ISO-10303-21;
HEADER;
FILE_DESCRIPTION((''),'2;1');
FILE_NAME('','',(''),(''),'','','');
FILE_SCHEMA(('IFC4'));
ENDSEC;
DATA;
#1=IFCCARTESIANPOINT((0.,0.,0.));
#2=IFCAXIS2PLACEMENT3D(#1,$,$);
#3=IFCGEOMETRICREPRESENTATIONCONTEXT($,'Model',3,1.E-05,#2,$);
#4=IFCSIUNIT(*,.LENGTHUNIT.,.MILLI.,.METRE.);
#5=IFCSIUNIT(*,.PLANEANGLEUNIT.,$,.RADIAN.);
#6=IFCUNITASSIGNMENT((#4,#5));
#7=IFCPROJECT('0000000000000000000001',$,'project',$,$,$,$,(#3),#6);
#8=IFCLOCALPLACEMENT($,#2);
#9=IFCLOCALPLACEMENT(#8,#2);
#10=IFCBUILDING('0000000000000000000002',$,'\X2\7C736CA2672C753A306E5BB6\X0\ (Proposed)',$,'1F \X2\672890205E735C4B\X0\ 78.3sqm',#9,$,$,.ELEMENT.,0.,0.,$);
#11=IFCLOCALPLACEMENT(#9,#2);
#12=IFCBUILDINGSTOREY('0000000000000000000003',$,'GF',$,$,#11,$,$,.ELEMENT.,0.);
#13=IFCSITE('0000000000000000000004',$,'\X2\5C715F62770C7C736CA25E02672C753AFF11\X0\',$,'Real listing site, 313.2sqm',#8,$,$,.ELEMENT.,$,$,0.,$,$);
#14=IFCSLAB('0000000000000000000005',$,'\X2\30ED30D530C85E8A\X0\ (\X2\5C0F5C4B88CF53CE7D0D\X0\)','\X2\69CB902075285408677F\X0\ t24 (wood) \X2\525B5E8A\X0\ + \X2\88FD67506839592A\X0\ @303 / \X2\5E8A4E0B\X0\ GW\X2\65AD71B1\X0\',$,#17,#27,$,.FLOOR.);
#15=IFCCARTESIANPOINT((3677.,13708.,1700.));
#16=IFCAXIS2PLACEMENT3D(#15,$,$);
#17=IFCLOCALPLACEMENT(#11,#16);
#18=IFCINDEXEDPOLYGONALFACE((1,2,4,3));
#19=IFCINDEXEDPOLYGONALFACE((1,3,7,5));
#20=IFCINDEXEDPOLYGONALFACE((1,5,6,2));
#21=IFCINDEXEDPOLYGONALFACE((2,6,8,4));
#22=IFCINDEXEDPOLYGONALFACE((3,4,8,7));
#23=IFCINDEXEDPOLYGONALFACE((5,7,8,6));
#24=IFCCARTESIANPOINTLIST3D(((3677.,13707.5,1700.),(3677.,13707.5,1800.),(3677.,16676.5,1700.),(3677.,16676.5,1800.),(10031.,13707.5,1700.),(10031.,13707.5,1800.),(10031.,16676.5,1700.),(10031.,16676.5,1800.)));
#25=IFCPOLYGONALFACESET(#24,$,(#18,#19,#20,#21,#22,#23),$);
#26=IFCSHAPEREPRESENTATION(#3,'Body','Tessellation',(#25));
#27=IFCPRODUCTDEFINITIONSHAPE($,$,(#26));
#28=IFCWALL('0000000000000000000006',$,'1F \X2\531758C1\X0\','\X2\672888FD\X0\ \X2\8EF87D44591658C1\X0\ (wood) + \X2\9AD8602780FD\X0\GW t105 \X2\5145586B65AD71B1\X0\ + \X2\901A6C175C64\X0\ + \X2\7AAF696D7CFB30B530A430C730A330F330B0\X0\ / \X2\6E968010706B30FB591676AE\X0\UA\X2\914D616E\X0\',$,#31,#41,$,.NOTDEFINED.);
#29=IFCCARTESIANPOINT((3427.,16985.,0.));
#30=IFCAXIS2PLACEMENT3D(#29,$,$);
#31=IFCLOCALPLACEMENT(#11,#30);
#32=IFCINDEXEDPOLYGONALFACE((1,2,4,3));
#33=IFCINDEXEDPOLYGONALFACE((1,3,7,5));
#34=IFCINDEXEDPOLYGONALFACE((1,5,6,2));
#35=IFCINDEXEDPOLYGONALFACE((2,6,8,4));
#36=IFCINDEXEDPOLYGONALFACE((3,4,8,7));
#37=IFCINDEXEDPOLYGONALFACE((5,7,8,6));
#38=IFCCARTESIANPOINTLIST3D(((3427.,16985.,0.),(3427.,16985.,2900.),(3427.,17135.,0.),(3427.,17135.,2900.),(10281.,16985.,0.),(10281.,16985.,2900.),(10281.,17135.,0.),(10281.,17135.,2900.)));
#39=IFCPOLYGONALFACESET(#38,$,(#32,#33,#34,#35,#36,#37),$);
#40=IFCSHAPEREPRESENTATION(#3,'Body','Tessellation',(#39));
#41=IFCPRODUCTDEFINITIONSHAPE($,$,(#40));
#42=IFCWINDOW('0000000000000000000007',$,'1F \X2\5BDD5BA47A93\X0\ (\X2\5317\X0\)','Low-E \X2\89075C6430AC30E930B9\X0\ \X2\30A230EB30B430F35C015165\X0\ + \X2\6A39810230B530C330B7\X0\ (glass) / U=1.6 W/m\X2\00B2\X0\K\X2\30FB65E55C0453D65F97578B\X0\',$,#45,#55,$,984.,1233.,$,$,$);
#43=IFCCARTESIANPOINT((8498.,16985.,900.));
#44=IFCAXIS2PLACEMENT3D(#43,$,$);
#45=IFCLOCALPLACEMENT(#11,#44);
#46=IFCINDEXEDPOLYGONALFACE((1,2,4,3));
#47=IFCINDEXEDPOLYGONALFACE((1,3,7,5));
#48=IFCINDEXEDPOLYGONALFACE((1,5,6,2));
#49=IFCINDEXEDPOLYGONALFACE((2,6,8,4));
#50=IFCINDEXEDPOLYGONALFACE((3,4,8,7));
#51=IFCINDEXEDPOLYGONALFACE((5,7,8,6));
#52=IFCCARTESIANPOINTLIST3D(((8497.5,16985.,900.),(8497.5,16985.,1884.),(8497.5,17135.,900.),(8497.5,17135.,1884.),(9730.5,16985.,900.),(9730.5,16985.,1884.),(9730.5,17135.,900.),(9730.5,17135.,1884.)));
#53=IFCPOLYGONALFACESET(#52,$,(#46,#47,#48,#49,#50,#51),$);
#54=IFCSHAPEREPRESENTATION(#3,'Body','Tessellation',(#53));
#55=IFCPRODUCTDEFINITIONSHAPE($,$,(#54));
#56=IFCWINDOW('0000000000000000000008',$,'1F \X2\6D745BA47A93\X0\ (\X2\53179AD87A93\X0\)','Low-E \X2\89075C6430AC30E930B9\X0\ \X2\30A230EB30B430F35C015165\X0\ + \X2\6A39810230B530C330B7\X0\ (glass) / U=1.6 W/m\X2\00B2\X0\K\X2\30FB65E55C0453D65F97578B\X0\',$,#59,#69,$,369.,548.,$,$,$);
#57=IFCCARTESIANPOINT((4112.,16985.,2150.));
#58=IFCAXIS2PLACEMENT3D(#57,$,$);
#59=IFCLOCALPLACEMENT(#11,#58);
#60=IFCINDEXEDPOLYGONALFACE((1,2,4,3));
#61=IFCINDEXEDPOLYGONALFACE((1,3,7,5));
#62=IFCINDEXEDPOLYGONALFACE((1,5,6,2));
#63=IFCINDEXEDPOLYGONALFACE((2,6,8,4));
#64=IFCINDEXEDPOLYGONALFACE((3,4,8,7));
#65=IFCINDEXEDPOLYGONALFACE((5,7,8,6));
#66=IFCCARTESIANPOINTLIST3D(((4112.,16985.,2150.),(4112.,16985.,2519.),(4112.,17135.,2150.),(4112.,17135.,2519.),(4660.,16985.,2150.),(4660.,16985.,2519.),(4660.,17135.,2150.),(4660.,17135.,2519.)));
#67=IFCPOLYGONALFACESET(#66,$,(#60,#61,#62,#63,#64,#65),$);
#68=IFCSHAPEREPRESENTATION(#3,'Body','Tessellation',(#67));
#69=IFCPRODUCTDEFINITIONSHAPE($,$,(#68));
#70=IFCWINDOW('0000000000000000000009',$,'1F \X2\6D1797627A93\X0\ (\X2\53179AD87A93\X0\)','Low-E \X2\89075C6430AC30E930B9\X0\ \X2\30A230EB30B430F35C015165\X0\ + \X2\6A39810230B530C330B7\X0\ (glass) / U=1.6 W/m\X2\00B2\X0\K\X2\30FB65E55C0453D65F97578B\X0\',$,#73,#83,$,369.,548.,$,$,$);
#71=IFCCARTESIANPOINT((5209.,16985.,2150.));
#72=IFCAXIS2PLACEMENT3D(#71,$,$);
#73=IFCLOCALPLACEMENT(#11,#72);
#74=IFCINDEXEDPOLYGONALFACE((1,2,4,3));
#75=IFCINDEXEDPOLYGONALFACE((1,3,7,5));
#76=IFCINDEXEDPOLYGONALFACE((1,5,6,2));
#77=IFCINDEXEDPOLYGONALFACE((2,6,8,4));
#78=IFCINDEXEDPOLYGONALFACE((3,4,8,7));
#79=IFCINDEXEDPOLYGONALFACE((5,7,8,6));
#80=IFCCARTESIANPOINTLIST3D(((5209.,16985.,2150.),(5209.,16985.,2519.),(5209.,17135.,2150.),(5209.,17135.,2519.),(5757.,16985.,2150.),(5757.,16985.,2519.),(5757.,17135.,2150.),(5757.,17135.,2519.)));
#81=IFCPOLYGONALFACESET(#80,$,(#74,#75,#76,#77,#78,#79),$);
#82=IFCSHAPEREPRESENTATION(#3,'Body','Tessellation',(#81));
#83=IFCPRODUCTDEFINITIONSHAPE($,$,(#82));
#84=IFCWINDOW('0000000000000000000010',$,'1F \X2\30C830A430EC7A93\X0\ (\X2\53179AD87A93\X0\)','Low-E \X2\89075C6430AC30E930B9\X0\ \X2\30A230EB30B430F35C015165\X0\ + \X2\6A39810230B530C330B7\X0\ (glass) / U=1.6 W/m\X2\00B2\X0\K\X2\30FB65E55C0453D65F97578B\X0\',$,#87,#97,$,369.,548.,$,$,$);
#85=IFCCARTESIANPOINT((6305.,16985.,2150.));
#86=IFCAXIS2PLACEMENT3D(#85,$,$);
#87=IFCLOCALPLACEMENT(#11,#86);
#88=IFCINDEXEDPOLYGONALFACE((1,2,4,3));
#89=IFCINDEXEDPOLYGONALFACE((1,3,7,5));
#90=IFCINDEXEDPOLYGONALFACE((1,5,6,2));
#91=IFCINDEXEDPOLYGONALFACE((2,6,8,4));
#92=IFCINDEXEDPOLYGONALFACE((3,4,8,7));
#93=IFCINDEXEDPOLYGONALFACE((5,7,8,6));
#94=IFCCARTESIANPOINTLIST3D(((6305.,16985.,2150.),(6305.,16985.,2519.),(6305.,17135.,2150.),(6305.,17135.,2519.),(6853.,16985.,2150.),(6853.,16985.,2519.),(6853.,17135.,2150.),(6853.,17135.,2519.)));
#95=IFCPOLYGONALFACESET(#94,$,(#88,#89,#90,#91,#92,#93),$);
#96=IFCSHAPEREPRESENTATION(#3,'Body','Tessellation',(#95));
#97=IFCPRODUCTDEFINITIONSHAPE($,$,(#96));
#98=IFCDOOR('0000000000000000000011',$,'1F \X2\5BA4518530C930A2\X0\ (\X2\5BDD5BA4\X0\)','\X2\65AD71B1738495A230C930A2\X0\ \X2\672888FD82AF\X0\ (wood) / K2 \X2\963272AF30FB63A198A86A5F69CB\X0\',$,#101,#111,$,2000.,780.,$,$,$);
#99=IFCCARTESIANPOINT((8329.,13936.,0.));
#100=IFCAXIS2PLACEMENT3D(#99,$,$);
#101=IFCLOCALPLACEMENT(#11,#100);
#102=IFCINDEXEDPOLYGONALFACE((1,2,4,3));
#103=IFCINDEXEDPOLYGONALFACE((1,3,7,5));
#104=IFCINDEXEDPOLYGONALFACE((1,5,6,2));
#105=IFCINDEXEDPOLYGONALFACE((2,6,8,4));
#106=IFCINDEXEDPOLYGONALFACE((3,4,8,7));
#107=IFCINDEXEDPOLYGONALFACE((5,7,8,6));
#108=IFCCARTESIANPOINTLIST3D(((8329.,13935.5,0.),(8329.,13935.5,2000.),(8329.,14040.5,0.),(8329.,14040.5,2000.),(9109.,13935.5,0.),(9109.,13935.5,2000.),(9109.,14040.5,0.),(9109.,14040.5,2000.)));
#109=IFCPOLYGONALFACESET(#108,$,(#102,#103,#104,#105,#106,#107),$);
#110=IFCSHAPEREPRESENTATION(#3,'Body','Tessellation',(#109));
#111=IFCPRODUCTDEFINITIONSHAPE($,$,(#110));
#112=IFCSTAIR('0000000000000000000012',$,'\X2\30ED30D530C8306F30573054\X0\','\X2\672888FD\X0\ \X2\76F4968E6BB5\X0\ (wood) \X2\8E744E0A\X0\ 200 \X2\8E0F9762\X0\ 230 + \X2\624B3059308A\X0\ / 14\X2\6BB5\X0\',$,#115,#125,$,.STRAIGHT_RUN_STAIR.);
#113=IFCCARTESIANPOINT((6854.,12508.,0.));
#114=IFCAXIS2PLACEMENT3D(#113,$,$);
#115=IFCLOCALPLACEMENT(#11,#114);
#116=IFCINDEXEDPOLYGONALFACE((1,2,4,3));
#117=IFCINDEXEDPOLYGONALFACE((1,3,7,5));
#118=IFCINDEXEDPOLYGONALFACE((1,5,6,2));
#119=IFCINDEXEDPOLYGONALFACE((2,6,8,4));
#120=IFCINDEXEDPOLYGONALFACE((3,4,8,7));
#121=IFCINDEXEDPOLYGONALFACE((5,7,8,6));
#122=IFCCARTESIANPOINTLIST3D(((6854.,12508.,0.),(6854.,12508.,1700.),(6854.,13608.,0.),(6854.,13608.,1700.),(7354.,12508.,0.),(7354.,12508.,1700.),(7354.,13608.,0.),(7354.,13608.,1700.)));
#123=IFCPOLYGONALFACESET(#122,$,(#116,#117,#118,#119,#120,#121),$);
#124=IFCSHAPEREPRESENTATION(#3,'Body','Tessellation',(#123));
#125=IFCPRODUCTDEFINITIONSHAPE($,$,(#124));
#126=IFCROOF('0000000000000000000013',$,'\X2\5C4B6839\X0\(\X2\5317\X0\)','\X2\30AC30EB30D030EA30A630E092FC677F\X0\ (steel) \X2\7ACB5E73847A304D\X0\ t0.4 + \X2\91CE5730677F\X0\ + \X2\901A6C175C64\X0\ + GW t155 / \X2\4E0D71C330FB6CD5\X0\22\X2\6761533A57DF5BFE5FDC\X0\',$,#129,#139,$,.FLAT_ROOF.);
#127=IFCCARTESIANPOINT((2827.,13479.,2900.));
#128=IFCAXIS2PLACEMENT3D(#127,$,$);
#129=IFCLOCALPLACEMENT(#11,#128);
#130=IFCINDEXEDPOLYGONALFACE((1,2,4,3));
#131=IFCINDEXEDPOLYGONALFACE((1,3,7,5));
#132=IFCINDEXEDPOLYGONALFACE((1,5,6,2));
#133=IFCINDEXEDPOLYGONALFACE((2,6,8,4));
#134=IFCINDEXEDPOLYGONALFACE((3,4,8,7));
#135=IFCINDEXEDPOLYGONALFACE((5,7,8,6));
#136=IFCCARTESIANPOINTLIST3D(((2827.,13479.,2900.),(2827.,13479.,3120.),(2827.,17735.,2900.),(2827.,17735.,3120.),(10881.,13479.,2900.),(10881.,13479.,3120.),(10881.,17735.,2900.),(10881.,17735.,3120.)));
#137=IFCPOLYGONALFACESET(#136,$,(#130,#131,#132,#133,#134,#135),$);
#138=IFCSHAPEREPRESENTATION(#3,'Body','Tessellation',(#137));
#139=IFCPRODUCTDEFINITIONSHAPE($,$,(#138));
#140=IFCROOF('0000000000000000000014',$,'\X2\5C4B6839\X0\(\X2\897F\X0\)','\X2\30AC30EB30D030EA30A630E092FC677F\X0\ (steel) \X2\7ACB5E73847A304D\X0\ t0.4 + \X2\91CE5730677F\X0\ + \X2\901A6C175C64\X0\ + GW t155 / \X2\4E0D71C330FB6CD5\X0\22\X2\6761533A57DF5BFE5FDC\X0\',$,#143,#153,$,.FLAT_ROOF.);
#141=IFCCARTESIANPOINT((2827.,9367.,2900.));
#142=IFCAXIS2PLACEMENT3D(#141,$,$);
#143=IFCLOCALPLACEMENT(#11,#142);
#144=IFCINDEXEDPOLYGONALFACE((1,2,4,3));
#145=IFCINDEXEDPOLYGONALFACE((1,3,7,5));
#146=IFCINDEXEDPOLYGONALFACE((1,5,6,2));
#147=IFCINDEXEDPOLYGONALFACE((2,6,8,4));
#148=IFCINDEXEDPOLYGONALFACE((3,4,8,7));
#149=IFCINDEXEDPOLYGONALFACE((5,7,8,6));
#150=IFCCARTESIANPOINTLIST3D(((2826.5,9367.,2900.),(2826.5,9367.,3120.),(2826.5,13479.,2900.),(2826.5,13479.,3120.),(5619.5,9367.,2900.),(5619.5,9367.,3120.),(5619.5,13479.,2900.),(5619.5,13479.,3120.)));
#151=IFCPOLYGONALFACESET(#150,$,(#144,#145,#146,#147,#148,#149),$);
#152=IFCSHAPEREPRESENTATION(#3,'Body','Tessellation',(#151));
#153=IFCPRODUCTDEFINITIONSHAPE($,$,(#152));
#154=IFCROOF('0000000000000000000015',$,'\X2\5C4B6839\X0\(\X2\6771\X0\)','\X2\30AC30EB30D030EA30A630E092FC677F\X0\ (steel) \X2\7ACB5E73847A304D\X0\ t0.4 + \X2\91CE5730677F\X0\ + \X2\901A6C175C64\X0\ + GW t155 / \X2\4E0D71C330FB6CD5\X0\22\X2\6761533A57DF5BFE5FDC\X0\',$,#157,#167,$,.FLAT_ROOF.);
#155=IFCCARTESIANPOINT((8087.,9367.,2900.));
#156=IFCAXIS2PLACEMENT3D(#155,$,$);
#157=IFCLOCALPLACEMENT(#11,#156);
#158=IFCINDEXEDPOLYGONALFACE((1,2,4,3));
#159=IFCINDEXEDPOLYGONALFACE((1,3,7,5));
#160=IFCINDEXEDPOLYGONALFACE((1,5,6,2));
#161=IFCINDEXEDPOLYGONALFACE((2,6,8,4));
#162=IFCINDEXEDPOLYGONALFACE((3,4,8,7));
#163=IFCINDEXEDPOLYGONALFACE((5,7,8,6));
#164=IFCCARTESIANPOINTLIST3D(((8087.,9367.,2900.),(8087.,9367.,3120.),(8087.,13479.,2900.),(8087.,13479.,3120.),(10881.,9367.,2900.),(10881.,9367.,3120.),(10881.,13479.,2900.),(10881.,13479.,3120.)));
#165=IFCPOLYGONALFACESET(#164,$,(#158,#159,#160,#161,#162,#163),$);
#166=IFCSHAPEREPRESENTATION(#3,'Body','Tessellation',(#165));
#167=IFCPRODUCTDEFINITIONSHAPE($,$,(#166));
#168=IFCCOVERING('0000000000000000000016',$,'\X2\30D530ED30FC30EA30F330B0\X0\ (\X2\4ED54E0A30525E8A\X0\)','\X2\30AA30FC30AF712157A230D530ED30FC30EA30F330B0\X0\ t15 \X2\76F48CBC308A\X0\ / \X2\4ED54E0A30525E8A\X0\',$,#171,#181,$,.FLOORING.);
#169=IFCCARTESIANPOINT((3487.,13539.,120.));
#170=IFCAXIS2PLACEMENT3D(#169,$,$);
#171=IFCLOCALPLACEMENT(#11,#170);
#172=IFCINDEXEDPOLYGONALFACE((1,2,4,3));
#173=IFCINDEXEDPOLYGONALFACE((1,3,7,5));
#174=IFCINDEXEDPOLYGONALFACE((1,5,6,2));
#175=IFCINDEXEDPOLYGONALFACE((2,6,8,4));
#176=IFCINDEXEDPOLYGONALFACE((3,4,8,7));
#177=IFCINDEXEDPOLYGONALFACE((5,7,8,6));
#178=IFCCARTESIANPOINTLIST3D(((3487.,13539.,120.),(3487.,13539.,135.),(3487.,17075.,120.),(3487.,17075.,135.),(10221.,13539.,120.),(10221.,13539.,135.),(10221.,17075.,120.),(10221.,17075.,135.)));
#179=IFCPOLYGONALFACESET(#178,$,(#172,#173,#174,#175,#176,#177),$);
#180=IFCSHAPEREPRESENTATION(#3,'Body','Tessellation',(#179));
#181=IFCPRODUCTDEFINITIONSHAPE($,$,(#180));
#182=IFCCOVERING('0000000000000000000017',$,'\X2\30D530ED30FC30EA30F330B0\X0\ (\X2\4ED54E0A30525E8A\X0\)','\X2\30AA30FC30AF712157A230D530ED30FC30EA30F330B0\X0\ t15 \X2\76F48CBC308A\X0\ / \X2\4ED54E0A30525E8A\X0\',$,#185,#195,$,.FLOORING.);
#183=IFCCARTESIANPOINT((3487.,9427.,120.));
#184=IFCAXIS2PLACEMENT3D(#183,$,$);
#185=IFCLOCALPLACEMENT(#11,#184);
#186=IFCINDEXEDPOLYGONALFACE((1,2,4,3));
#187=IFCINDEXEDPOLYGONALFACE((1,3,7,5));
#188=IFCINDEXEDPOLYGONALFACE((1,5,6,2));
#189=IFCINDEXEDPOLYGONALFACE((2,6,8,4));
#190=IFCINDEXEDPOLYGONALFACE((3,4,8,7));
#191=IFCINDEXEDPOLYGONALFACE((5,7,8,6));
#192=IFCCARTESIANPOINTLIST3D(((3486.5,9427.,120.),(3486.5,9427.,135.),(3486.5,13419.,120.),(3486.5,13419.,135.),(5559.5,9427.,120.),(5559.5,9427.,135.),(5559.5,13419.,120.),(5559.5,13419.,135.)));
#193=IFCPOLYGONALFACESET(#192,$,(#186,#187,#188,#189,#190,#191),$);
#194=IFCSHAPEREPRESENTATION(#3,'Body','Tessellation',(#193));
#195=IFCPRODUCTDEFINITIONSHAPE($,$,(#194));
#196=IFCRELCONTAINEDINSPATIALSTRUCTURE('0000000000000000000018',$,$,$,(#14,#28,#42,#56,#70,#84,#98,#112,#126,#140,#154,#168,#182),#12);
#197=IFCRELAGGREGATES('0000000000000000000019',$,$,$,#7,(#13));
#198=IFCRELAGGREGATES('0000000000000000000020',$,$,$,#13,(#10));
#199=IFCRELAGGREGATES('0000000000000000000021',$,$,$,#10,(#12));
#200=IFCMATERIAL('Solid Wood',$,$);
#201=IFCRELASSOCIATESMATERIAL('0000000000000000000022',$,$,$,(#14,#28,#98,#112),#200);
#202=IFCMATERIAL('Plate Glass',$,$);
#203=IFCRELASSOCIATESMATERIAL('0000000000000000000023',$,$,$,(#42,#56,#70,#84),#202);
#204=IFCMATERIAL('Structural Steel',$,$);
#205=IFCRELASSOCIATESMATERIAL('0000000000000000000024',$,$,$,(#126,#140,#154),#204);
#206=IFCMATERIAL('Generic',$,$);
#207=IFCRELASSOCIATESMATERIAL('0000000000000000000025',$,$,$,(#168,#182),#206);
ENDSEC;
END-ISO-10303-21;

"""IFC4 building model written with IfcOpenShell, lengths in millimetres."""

from ifc_helpers import new_model, si_unit, frame, frame_2d, origin, place, context, project, spatial, rectangle, extrude, material, element, fill, save


model = new_model("IFC4")

# Units and contexts
model_context = context("Model", 3, precision=1e-05, world=origin())
ifc_project = project(units=[si_unit("LENGTHUNIT", "METRE", prefix="MILLI"), si_unit("PLANEANGLEUNIT", "RADIAN")], contexts=[model_context])

# Site, building, storey
site_placement = place(None, origin())
site = spatial("IfcSite", under=ifc_project, at=site_placement, Name="山形県米沢市本町１", ObjectType="Real listing site, 313.2sqm", CompositionType="ELEMENT", RefElevation=0.0)
building_placement = place(site_placement, origin())
building = spatial("IfcBuilding", under=site, at=building_placement, Name="米沢本町の家 (Proposed)", ObjectType="1F 木造平屋 78.3sqm", CompositionType="ELEMENT", ElevationOfRefHeight=0.0, ElevationOfTerrain=0.0)
storey_placement = place(building_placement, origin())
storey = spatial("IfcBuildingStorey", under=building, at=storey_placement, Name="GF", CompositionType="ELEMENT", Elevation=0.0)

# Slab
ifc_material_1 = material(Name="Solid Wood")
slab_1_placement = place(storey_placement, frame((3677.0, 13708.0, 1700.0)))
element("IfcSlab", 1, at=slab_1_placement, inside=storey, material=ifc_material_1, Name="ロフト床 (小屋裏収納)", Description="構造用合板 t24 (wood) 剛床 + 製材根太 @303 / 床下 GW断熱", PredefinedType="FLOOR", context=model_context, shape_type="SweptSolid", body=[
    extrude(rectangle(XDim=6354.0, YDim=2969.0, at=frame_2d((3177.0, 1484.0))), frame((3677.0, 13708.0, 1700.0)), (0.0, 0.0, 1.0), 100.0),
])

# Wall, openings, windows
wall_1_placement = place(storey_placement, frame((3427.0, 16985.0, 0.0)))
wall_1 = element("IfcWall", 2, at=wall_1_placement, inside=storey, material=ifc_material_1, Name="1F 北壁", Description="木製 軸組外壁 (wood) + 高性能GW t105 充填断熱 + 通気層 + 窯業系サイディング / 準耐火・外皮UA配慮", PredefinedType="NOTDEFINED", context=model_context, shape_type="SweptSolid", body=[
    extrude(rectangle(XDim=6854.0, YDim=150.0, at=frame_2d((3427.0, 75.0))), frame((3427.0, 16985.0, 0.0)), (0.0, 0.0, 1.0), 2900.0),
])
opening_1_placement = place(storey_placement, frame((8498.0, 16985.0, 900.0)))
opening_1 = element("IfcOpeningElement", 3, at=opening_1_placement, cuts=wall_1, PredefinedType="NOTDEFINED", context=model_context, shape_type="SweptSolid", body=[
    extrude(rectangle(XDim=1233.0, YDim=150.0, at=frame_2d((616.0, 75.0))), frame((8498.0, 16985.0, 900.0)), (0.0, 0.0, 1.0), 984.0),
])
opening_2_placement = place(storey_placement, frame((4112.0, 16985.0, 2150.0)))
opening_2 = element("IfcOpeningElement", 4, at=opening_2_placement, cuts=wall_1, PredefinedType="NOTDEFINED", context=model_context, shape_type="SweptSolid", body=[
    extrude(rectangle(XDim=548.0, YDim=150.0, at=frame_2d((274.0, 75.0))), frame((4112.0, 16985.0, 2150.0)), (0.0, 0.0, 1.0), 369.0),
])
opening_3_placement = place(storey_placement, frame((5209.0, 16985.0, 2150.0)))
opening_3 = element("IfcOpeningElement", 5, at=opening_3_placement, cuts=wall_1, PredefinedType="NOTDEFINED", context=model_context, shape_type="SweptSolid", body=[
    extrude(rectangle(XDim=548.0, YDim=150.0, at=frame_2d((274.0, 75.0))), frame((5209.0, 16985.0, 2150.0)), (0.0, 0.0, 1.0), 369.0),
])
opening_4_placement = place(storey_placement, frame((6305.0, 16985.0, 2150.0)))
opening_4 = element("IfcOpeningElement", 6, at=opening_4_placement, cuts=wall_1, PredefinedType="NOTDEFINED", context=model_context, shape_type="SweptSolid", body=[
    extrude(rectangle(XDim=548.0, YDim=150.0, at=frame_2d((274.0, 75.0))), frame((6305.0, 16985.0, 2150.0)), (0.0, 0.0, 1.0), 369.0),
])
ifc_material_2 = material(Name="Plate Glass")
window_1_placement = place(storey_placement, frame((8498.0, 16985.0, 900.0)))
window_1 = element("IfcWindow", 7, at=window_1_placement, inside=storey, material=ifc_material_2, Name="1F 寝室窓 (北)", Description="Low-E 複層ガラス アルゴン封入 + 樹脂サッシ (glass) / U=1.6 W/m²K・日射取得型", OverallHeight=984.0, OverallWidth=1233.0, context=model_context, shape_type="SweptSolid", body=[
    extrude(rectangle(XDim=1233.0, YDim=150.0, at=frame_2d((616.0, 75.0))), frame((8498.0, 16985.0, 900.0)), (0.0, 0.0, 1.0), 984.0),
])
fill(opening_1, window_1)
window_2_placement = place(storey_placement, frame((4112.0, 16985.0, 2150.0)))
window_2 = element("IfcWindow", 8, at=window_2_placement, inside=storey, material=ifc_material_2, Name="1F 浴室窓 (北高窓)", Description="Low-E 複層ガラス アルゴン封入 + 樹脂サッシ (glass) / U=1.6 W/m²K・日射取得型", OverallHeight=369.0, OverallWidth=548.0, context=model_context, shape_type="SweptSolid", body=[
    extrude(rectangle(XDim=548.0, YDim=150.0, at=frame_2d((274.0, 75.0))), frame((4112.0, 16985.0, 2150.0)), (0.0, 0.0, 1.0), 369.0),
])
fill(opening_2, window_2)
window_3_placement = place(storey_placement, frame((5209.0, 16985.0, 2150.0)))
window_3 = element("IfcWindow", 9, at=window_3_placement, inside=storey, material=ifc_material_2, Name="1F 洗面窓 (北高窓)", Description="Low-E 複層ガラス アルゴン封入 + 樹脂サッシ (glass) / U=1.6 W/m²K・日射取得型", OverallHeight=369.0, OverallWidth=548.0, context=model_context, shape_type="SweptSolid", body=[
    extrude(rectangle(XDim=548.0, YDim=150.0, at=frame_2d((274.0, 75.0))), frame((5209.0, 16985.0, 2150.0)), (0.0, 0.0, 1.0), 369.0),
])
fill(opening_3, window_3)
window_4_placement = place(storey_placement, frame((6305.0, 16985.0, 2150.0)))
window_4 = element("IfcWindow", 10, at=window_4_placement, inside=storey, material=ifc_material_2, Name="1F トイレ窓 (北高窓)", Description="Low-E 複層ガラス アルゴン封入 + 樹脂サッシ (glass) / U=1.6 W/m²K・日射取得型", OverallHeight=369.0, OverallWidth=548.0, context=model_context, shape_type="SweptSolid", body=[
    extrude(rectangle(XDim=548.0, YDim=150.0, at=frame_2d((274.0, 75.0))), frame((6305.0, 16985.0, 2150.0)), (0.0, 0.0, 1.0), 369.0),
])
fill(opening_4, window_4)

# Door
door_1_placement = place(storey_placement, frame((8329.0, 13936.0, 0.0)))
element("IfcDoor", 11, at=door_1_placement, inside=storey, material=ifc_material_1, Name="1F 室内ドア (寝室)", Description="断熱玄関ドア 木製芯 (wood) / K2 防犯・採風機構", OverallHeight=2000.0, OverallWidth=780.0, context=model_context, shape_type="SweptSolid", body=[
    extrude(rectangle(XDim=780.0, YDim=105.0, at=frame_2d((390.0, 52.0))), frame((8329.0, 13936.0, 0.0)), (0.0, 0.0, 1.0), 2000.0),
])

# Stair
stair_placement = place(storey_placement, frame((6854.0, 12508.0, 0.0)))
element("IfcStair", 12, at=stair_placement, inside=storey, material=ifc_material_1, Name="ロフトはしご", Description="木製 直階段 (wood) 蹴上 200 踏面 230 + 手すり / 14段", PredefinedType="STRAIGHT_RUN_STAIR", context=model_context, shape_type="SweptSolid", body=[
    extrude(rectangle(XDim=500.0, YDim=1100.0, at=frame_2d((250.0, 550.0))), frame((6854.0, 12508.0, 0.0)), (0.0, 0.0, 1.0), 1700.0),
])

# Roofs
ifc_material_3 = material(Name="Structural Steel")
roof_1_placement = place(storey_placement, frame((2827.0, 13479.0, 2900.0)))
element("IfcRoof", 13, at=roof_1_placement, inside=storey, material=ifc_material_3, Name="屋根(北)", Description="ガルバリウム鋼板 (steel) 立平葺き t0.4 + 野地板 + 通気層 + GW t155 / 不燃・法22条区域対応", PredefinedType="FLAT_ROOF", context=model_context, shape_type="SweptSolid", body=[
    extrude(rectangle(XDim=8054.0, YDim=4256.0, at=frame_2d((4027.0, 2128.0))), frame((2827.0, 13479.0, 2900.0)), (0.0, 0.0, 1.0), 220.0),
])
roof_2_placement = place(storey_placement, frame((2827.0, 9367.0, 2900.0)))
element("IfcRoof", 14, at=roof_2_placement, inside=storey, material=ifc_material_3, Name="屋根(西)", Description="ガルバリウム鋼板 (steel) 立平葺き t0.4 + 野地板 + 通気層 + GW t155 / 不燃・法22条区域対応", PredefinedType="FLAT_ROOF", context=model_context, shape_type="SweptSolid", body=[
    extrude(rectangle(XDim=2793.0, YDim=4112.0, at=frame_2d((1396.0, 2056.0))), frame((2827.0, 9367.0, 2900.0)), (0.0, 0.0, 1.0), 220.0),
])
roof_3_placement = place(storey_placement, frame((8087.0, 9367.0, 2900.0)))
element("IfcRoof", 15, at=roof_3_placement, inside=storey, material=ifc_material_3, Name="屋根(東)", Description="ガルバリウム鋼板 (steel) 立平葺き t0.4 + 野地板 + 通気層 + GW t155 / 不燃・法22条区域対応", PredefinedType="FLAT_ROOF", context=model_context, shape_type="SweptSolid", body=[
    extrude(rectangle(XDim=2794.0, YDim=4112.0, at=frame_2d((1397.0, 2056.0))), frame((8087.0, 9367.0, 2900.0)), (0.0, 0.0, 1.0), 220.0),
])

# Coverings
ifc_material_4 = material(Name="Generic")
covering_1_placement = place(storey_placement, frame((3487.0, 13539.0, 120.0)))
element("IfcCovering", 16, at=covering_1_placement, inside=storey, material=ifc_material_4, Name="フローリング (仕上げ床)", Description="オーク無垢フローリング t15 直貼り / 仕上げ床", PredefinedType="FLOORING", context=model_context, shape_type="SweptSolid", body=[
    extrude(rectangle(XDim=6734.0, YDim=3536.0, at=frame_2d((3367.0, 1768.0))), frame((3487.0, 13539.0, 120.0)), (0.0, 0.0, 1.0), 15.0),
])
covering_2_placement = place(storey_placement, frame((3487.0, 9427.0, 120.0)))
element("IfcCovering", 17, at=covering_2_placement, inside=storey, material=ifc_material_4, Name="フローリング (仕上げ床)", Description="オーク無垢フローリング t15 直貼り / 仕上げ床", PredefinedType="FLOORING", context=model_context, shape_type="SweptSolid", body=[
    extrude(rectangle(XDim=2073.0, YDim=3992.0, at=frame_2d((1036.0, 1996.0))), frame((3487.0, 9427.0, 120.0)), (0.0, 0.0, 1.0), 15.0),
])

save(model, "model.ifc")
